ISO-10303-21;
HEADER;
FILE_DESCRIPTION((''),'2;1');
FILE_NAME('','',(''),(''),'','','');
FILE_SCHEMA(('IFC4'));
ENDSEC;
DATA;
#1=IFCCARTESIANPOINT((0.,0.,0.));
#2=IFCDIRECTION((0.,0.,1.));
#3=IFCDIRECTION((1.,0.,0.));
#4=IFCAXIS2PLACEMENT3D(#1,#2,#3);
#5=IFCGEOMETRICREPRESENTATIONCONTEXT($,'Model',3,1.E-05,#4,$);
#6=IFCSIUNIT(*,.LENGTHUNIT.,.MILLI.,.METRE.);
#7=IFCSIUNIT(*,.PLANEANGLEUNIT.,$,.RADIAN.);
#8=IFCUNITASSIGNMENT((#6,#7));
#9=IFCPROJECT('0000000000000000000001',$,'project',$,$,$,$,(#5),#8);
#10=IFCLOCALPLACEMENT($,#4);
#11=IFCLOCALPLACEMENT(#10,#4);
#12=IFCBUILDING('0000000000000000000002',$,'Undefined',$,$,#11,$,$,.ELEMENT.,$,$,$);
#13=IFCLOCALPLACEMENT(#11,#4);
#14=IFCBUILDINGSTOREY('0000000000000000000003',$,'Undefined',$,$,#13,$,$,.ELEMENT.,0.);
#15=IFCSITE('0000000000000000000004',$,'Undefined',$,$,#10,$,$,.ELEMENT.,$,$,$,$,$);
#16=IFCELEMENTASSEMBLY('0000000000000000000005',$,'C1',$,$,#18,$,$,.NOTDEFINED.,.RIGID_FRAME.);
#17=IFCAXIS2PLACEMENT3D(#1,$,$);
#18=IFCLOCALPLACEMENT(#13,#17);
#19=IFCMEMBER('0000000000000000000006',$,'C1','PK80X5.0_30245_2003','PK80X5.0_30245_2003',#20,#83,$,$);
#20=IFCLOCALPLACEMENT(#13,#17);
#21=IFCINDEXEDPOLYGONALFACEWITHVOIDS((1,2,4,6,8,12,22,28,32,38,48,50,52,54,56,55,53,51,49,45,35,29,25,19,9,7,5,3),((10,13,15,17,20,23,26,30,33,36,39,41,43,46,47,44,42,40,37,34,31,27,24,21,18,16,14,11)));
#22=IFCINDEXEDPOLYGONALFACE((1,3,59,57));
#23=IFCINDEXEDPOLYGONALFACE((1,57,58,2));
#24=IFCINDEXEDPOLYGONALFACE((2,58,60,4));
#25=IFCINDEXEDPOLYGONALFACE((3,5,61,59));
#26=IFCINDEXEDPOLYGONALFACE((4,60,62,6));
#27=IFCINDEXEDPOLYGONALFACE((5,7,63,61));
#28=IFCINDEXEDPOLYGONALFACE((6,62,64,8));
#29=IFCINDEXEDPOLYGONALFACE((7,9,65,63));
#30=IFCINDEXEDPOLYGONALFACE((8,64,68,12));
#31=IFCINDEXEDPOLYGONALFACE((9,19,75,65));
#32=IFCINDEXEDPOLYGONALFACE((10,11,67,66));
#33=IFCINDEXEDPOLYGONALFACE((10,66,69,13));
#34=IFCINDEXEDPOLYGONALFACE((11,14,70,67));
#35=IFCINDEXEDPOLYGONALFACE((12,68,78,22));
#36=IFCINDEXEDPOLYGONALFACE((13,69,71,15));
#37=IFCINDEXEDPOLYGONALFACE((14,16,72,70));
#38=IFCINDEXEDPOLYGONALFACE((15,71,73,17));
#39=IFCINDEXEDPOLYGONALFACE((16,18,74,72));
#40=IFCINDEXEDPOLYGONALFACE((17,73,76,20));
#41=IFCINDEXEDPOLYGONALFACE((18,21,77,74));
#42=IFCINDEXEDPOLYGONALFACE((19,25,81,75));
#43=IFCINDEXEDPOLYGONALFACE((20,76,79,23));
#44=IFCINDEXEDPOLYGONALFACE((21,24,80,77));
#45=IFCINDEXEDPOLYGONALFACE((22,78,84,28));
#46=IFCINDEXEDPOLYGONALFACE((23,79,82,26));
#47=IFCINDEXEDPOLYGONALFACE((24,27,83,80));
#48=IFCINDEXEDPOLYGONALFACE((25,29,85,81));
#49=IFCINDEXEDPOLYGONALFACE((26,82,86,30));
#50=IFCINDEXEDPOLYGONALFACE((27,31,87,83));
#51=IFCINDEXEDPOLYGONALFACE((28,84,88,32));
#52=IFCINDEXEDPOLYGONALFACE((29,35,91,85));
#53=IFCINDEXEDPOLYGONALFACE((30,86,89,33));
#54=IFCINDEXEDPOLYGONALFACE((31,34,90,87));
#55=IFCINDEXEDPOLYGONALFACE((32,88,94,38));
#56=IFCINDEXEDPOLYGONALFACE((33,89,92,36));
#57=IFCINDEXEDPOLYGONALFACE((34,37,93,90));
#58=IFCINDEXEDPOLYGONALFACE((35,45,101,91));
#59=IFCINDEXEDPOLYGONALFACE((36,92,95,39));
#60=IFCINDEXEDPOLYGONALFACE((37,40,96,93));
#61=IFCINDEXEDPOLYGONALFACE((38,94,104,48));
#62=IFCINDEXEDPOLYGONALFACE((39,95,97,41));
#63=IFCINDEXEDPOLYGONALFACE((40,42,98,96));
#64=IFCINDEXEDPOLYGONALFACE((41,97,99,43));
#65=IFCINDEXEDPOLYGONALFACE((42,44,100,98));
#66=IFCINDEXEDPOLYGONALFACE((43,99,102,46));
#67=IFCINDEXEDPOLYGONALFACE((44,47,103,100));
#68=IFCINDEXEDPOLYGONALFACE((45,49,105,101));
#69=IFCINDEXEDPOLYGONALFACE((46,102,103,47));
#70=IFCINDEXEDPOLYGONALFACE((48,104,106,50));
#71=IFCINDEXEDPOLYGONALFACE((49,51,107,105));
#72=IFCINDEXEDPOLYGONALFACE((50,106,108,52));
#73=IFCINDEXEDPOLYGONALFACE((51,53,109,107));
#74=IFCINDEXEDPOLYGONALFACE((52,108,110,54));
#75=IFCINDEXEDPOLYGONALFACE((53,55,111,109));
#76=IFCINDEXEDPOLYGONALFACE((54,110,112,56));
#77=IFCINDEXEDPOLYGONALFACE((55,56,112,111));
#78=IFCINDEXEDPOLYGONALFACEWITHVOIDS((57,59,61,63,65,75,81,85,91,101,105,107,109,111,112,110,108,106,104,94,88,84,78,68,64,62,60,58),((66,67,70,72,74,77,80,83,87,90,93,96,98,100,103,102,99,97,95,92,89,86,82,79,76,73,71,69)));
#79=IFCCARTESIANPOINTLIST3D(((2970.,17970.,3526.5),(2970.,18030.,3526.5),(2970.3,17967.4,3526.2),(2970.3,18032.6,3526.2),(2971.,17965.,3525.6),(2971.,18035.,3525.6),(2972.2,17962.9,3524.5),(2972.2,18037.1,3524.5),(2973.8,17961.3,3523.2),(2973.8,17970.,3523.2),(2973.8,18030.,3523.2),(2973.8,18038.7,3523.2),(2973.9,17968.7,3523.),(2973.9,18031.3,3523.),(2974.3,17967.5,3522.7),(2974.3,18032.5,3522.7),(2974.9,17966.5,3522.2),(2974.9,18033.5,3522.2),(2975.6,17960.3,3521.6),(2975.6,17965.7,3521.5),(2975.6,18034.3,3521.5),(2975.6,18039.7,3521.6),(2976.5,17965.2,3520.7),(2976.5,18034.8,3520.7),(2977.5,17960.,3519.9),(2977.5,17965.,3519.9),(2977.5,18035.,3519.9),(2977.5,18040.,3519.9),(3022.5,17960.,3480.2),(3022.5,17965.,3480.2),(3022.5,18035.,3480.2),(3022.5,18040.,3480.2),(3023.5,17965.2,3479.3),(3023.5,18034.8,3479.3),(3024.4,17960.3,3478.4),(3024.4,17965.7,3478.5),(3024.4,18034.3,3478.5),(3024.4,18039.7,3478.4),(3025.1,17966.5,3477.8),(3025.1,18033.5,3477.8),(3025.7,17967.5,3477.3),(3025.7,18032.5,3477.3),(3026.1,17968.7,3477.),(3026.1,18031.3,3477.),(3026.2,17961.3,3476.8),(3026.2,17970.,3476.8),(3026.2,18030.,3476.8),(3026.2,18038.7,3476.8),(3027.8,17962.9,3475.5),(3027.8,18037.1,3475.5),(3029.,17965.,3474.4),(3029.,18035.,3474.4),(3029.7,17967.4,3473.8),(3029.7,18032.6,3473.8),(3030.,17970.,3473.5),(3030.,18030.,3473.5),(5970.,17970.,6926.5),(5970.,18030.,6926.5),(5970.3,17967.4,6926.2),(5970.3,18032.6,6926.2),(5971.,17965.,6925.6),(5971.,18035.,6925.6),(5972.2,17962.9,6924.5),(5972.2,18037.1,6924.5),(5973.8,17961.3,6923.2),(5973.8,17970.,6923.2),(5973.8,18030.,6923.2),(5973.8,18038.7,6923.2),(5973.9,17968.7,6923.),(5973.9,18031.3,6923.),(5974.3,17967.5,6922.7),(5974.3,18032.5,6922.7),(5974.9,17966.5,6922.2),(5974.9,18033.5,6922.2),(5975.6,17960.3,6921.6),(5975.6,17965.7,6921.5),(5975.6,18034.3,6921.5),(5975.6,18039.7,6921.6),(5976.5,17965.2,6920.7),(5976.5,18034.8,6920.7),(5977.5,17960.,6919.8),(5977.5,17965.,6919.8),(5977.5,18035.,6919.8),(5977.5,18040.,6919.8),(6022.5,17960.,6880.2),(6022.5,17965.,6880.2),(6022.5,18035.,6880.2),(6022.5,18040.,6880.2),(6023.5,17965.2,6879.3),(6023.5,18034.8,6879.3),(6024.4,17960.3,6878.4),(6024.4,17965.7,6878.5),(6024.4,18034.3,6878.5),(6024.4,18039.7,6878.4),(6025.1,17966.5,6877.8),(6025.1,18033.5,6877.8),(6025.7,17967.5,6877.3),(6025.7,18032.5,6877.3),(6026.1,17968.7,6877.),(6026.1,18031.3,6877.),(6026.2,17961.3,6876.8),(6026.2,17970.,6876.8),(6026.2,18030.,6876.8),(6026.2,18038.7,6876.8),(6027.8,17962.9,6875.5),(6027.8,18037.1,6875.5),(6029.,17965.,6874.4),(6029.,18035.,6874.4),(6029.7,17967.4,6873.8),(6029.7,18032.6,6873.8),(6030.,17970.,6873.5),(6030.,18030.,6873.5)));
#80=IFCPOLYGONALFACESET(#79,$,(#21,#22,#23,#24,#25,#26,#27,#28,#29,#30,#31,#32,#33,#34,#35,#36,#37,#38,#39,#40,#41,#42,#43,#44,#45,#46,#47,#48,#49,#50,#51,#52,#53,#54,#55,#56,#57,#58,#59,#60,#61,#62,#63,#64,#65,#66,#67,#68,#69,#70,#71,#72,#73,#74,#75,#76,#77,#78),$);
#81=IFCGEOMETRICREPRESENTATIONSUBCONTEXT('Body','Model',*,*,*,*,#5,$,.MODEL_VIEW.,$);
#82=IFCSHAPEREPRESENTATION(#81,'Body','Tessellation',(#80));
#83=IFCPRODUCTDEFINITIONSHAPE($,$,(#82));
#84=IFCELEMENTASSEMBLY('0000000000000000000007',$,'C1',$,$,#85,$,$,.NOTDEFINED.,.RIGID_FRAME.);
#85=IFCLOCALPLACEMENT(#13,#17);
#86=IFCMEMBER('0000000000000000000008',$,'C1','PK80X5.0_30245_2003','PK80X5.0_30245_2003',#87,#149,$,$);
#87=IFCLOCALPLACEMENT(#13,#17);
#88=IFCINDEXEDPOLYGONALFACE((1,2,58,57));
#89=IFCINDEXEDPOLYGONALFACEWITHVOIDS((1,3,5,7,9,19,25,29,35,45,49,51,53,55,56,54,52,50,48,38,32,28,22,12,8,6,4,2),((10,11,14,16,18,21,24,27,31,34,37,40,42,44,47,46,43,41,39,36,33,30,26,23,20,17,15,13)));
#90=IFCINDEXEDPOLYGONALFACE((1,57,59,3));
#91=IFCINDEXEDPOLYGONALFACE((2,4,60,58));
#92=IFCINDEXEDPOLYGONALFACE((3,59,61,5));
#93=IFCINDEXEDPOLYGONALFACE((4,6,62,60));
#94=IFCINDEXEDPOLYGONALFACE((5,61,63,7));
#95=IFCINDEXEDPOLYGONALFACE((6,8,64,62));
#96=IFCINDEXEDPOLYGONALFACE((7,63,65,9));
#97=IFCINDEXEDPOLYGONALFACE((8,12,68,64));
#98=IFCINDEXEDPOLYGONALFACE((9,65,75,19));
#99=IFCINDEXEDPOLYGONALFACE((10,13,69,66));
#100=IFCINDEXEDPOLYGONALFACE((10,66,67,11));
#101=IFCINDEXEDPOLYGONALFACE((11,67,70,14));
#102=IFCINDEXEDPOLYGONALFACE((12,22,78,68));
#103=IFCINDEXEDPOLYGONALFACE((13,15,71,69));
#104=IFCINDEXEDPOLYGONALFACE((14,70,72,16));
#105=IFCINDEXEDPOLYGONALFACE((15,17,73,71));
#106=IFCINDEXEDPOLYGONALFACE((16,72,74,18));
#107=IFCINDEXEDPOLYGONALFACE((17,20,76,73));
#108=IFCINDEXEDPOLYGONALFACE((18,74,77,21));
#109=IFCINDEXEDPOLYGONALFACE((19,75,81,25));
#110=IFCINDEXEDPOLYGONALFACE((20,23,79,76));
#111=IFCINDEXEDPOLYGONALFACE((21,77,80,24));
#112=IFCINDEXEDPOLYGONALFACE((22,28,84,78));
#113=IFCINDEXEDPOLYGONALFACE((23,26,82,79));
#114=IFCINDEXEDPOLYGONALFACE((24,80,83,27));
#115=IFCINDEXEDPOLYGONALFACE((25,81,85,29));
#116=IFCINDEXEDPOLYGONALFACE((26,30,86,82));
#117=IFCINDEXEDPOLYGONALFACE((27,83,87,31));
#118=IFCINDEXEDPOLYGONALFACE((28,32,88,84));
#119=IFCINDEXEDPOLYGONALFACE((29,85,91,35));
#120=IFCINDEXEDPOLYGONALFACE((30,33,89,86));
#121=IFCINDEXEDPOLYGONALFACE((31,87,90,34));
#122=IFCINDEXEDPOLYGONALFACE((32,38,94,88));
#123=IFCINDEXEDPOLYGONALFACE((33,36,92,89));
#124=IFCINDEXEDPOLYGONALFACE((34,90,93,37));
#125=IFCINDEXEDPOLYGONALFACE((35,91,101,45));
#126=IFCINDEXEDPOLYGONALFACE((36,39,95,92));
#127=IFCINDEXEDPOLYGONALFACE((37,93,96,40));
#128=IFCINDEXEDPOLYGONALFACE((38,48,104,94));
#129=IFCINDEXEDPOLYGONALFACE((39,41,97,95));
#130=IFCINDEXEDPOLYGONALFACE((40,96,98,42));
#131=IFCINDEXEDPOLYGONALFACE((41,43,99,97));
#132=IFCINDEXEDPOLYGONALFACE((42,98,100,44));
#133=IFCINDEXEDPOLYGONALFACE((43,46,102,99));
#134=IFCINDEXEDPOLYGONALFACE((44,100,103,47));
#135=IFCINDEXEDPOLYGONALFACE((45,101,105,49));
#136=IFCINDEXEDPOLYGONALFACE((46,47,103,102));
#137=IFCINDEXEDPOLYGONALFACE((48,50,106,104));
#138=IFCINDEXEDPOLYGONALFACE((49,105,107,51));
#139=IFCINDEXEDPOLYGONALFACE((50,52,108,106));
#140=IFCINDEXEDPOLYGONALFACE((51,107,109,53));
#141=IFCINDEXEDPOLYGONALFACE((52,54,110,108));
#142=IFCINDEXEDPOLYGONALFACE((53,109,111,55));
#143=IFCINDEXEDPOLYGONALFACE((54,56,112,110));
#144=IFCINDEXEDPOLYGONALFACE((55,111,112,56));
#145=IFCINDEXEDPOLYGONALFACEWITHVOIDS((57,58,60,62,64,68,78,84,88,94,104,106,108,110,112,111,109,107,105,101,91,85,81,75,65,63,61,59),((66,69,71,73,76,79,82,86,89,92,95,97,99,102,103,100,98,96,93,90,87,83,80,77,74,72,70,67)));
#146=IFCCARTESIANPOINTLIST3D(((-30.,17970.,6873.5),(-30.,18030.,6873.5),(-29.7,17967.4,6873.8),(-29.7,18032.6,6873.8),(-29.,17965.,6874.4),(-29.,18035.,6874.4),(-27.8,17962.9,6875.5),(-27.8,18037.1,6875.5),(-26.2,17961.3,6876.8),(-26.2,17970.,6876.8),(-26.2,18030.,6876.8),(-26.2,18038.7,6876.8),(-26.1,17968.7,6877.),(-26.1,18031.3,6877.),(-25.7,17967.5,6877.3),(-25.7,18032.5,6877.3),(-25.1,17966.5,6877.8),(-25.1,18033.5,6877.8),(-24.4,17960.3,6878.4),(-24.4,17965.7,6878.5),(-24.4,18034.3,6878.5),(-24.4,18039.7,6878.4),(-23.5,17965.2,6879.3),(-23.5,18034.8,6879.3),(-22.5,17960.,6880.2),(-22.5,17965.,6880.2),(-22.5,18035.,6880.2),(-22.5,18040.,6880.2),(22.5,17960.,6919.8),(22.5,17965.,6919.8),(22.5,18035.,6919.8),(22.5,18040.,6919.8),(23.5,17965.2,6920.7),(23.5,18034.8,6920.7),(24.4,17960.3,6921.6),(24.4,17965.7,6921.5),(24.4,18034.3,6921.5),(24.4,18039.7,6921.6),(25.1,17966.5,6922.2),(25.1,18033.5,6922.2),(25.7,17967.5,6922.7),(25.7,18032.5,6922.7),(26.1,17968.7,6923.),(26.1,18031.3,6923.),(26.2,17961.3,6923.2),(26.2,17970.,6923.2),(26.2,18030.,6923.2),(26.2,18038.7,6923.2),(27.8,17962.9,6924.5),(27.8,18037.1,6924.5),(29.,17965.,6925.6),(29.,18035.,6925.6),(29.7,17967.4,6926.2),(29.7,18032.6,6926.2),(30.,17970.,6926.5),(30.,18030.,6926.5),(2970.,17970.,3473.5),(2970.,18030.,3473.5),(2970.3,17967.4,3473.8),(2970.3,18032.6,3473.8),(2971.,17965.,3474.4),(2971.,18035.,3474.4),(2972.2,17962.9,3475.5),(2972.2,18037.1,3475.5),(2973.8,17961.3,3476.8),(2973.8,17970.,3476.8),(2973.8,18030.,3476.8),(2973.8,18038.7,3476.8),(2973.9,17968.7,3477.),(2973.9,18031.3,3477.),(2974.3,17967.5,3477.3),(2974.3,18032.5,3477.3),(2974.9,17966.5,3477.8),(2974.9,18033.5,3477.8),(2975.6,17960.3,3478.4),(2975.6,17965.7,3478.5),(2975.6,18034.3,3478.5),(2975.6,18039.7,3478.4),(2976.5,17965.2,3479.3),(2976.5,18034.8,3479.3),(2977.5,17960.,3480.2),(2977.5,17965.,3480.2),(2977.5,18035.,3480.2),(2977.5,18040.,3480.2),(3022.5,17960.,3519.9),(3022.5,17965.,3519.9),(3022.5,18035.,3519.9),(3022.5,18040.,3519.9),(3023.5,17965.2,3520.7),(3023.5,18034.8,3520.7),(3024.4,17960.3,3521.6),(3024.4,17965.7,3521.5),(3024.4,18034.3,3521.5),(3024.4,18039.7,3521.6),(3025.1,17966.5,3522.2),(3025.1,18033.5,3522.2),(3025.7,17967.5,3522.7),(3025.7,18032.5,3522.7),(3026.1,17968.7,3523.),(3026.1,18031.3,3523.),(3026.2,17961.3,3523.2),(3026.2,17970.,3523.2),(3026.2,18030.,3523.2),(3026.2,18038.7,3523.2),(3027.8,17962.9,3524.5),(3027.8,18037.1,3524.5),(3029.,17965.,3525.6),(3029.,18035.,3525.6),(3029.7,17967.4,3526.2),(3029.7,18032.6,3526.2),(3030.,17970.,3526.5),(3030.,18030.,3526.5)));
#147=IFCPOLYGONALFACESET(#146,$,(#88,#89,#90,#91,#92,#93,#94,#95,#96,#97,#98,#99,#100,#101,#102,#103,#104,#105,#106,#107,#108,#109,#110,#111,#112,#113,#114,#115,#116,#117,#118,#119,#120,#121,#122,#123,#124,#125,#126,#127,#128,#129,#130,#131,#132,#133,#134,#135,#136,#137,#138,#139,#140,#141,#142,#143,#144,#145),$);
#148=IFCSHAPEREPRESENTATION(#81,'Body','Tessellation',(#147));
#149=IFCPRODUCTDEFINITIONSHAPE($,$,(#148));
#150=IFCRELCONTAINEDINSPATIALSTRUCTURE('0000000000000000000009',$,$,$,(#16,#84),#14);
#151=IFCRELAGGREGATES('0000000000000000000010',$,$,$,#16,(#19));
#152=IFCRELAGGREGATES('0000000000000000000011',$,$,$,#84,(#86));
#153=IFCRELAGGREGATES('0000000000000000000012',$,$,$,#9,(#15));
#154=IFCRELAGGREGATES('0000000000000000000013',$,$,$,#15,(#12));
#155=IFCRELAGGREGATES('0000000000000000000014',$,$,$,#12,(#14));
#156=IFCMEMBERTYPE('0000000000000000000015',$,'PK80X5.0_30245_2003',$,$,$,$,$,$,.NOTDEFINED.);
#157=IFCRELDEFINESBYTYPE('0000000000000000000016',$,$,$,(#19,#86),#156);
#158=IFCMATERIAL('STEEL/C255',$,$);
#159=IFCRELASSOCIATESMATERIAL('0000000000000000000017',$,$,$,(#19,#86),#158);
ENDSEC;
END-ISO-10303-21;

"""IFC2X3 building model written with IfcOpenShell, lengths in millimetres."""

from ifc_helpers import new_model, si_unit, frame, origin_with_axes, origin_2d_with_axis, place, context, subcontext, project, spatial, hollow_rectangle, extrude, material, type_object, element, aggregate, save


model = new_model("IFC2X3")

# Units and contexts
model_context = context("Model", 3, precision=1e-05, world=origin_with_axes())
body_context = subcontext(model_context, "Body", "Model", "MODEL_VIEW")
ifc_project = project(units=[si_unit("LENGTHUNIT", "METRE", prefix="MILLI"), si_unit("PLANEANGLEUNIT", "RADIAN")], contexts=[model_context])

# Site, building, storey
site_placement = place(None, origin_with_axes())
site = spatial("IfcSite", under=ifc_project, at=site_placement, Name="Undefined", CompositionType="ELEMENT")
building_placement = place(site_placement, origin_with_axes())
building = spatial("IfcBuilding", under=site, at=building_placement, Name="Undefined", CompositionType="ELEMENT")
storey_placement = place(building_placement, origin_with_axes())
storey = spatial("IfcBuildingStorey", under=building, at=storey_placement, Name="Undefined", CompositionType="ELEMENT", Elevation=0.0)

# Shared definitions
ifc_material_1 = material(Name="STEEL/C255")

# Element assemblies, members
assembly_1_placement = place(storey_placement, origin_with_axes())
assembly_1 = element("IfcElementAssembly", 1, at=assembly_1_placement, inside=storey, Name="C1", AssemblyPlace="NOTDEFINED", PredefinedType="RIGID_FRAME")
member_type = type_object("IfcMemberType", Name="PK80X5.0_30245_2003", PredefinedType="NOTDEFINED")
member_1_placement = place(assembly_1_placement, frame((3000.0, 18000.0, 3500.0), z_axis=(0.749838, 0.0, -0.661622), x_axis=(0.661622, 0.0, 0.749838)))
member_1 = element("IfcMember", 2, at=member_1_placement, type_object=member_type, material=ifc_material_1, Name="C1", Description="PK80X5.0_30245_2003", ObjectType="PK80X5.0_30245_2003", context=body_context, shape_type="SweptSolid", body=[
    extrude(hollow_rectangle(XDim=80.0, YDim=80.0, WallThickness=5.0, InnerFilletRadius=5.0, OuterFilletRadius=10.0, at=origin_2d_with_axis()), frame((4534.3, 0.0, 0.0), z_axis=(-1.0, 0.0, 0.0), x_axis=(0.0, -1.0, 0.0)), (0.0, 0.0, 1.0), 4534.3),
])
aggregate(assembly_1, [member_1])
assembly_2_placement = place(storey_placement, origin_with_axes())
assembly_2 = element("IfcElementAssembly", 3, at=assembly_2_placement, inside=storey, Name="C1", AssemblyPlace="NOTDEFINED", PredefinedType="RIGID_FRAME")
member_2_placement = place(assembly_2_placement, frame((3000.0, 18000.0, 3500.0), z_axis=(-0.749838, 0.0, -0.661622), x_axis=(-0.661622, 0.0, 0.749838)))
member_2 = element("IfcMember", 4, at=member_2_placement, type_object=member_type, material=ifc_material_1, Name="C1", Description="PK80X5.0_30245_2003", ObjectType="PK80X5.0_30245_2003", context=body_context, shape_type="SweptSolid", body=[
    extrude(hollow_rectangle(XDim=80.0, YDim=80.0, WallThickness=5.0, InnerFilletRadius=5.0, OuterFilletRadius=10.0, at=origin_2d_with_axis()), frame((4534.3, 0.0, 0.0), z_axis=(-1.0, 0.0, 0.0), x_axis=(0.0, -1.0, 0.0)), (0.0, 0.0, 1.0), 4534.3),
])
aggregate(assembly_2, [member_2])

save(model, "model.ifc")
